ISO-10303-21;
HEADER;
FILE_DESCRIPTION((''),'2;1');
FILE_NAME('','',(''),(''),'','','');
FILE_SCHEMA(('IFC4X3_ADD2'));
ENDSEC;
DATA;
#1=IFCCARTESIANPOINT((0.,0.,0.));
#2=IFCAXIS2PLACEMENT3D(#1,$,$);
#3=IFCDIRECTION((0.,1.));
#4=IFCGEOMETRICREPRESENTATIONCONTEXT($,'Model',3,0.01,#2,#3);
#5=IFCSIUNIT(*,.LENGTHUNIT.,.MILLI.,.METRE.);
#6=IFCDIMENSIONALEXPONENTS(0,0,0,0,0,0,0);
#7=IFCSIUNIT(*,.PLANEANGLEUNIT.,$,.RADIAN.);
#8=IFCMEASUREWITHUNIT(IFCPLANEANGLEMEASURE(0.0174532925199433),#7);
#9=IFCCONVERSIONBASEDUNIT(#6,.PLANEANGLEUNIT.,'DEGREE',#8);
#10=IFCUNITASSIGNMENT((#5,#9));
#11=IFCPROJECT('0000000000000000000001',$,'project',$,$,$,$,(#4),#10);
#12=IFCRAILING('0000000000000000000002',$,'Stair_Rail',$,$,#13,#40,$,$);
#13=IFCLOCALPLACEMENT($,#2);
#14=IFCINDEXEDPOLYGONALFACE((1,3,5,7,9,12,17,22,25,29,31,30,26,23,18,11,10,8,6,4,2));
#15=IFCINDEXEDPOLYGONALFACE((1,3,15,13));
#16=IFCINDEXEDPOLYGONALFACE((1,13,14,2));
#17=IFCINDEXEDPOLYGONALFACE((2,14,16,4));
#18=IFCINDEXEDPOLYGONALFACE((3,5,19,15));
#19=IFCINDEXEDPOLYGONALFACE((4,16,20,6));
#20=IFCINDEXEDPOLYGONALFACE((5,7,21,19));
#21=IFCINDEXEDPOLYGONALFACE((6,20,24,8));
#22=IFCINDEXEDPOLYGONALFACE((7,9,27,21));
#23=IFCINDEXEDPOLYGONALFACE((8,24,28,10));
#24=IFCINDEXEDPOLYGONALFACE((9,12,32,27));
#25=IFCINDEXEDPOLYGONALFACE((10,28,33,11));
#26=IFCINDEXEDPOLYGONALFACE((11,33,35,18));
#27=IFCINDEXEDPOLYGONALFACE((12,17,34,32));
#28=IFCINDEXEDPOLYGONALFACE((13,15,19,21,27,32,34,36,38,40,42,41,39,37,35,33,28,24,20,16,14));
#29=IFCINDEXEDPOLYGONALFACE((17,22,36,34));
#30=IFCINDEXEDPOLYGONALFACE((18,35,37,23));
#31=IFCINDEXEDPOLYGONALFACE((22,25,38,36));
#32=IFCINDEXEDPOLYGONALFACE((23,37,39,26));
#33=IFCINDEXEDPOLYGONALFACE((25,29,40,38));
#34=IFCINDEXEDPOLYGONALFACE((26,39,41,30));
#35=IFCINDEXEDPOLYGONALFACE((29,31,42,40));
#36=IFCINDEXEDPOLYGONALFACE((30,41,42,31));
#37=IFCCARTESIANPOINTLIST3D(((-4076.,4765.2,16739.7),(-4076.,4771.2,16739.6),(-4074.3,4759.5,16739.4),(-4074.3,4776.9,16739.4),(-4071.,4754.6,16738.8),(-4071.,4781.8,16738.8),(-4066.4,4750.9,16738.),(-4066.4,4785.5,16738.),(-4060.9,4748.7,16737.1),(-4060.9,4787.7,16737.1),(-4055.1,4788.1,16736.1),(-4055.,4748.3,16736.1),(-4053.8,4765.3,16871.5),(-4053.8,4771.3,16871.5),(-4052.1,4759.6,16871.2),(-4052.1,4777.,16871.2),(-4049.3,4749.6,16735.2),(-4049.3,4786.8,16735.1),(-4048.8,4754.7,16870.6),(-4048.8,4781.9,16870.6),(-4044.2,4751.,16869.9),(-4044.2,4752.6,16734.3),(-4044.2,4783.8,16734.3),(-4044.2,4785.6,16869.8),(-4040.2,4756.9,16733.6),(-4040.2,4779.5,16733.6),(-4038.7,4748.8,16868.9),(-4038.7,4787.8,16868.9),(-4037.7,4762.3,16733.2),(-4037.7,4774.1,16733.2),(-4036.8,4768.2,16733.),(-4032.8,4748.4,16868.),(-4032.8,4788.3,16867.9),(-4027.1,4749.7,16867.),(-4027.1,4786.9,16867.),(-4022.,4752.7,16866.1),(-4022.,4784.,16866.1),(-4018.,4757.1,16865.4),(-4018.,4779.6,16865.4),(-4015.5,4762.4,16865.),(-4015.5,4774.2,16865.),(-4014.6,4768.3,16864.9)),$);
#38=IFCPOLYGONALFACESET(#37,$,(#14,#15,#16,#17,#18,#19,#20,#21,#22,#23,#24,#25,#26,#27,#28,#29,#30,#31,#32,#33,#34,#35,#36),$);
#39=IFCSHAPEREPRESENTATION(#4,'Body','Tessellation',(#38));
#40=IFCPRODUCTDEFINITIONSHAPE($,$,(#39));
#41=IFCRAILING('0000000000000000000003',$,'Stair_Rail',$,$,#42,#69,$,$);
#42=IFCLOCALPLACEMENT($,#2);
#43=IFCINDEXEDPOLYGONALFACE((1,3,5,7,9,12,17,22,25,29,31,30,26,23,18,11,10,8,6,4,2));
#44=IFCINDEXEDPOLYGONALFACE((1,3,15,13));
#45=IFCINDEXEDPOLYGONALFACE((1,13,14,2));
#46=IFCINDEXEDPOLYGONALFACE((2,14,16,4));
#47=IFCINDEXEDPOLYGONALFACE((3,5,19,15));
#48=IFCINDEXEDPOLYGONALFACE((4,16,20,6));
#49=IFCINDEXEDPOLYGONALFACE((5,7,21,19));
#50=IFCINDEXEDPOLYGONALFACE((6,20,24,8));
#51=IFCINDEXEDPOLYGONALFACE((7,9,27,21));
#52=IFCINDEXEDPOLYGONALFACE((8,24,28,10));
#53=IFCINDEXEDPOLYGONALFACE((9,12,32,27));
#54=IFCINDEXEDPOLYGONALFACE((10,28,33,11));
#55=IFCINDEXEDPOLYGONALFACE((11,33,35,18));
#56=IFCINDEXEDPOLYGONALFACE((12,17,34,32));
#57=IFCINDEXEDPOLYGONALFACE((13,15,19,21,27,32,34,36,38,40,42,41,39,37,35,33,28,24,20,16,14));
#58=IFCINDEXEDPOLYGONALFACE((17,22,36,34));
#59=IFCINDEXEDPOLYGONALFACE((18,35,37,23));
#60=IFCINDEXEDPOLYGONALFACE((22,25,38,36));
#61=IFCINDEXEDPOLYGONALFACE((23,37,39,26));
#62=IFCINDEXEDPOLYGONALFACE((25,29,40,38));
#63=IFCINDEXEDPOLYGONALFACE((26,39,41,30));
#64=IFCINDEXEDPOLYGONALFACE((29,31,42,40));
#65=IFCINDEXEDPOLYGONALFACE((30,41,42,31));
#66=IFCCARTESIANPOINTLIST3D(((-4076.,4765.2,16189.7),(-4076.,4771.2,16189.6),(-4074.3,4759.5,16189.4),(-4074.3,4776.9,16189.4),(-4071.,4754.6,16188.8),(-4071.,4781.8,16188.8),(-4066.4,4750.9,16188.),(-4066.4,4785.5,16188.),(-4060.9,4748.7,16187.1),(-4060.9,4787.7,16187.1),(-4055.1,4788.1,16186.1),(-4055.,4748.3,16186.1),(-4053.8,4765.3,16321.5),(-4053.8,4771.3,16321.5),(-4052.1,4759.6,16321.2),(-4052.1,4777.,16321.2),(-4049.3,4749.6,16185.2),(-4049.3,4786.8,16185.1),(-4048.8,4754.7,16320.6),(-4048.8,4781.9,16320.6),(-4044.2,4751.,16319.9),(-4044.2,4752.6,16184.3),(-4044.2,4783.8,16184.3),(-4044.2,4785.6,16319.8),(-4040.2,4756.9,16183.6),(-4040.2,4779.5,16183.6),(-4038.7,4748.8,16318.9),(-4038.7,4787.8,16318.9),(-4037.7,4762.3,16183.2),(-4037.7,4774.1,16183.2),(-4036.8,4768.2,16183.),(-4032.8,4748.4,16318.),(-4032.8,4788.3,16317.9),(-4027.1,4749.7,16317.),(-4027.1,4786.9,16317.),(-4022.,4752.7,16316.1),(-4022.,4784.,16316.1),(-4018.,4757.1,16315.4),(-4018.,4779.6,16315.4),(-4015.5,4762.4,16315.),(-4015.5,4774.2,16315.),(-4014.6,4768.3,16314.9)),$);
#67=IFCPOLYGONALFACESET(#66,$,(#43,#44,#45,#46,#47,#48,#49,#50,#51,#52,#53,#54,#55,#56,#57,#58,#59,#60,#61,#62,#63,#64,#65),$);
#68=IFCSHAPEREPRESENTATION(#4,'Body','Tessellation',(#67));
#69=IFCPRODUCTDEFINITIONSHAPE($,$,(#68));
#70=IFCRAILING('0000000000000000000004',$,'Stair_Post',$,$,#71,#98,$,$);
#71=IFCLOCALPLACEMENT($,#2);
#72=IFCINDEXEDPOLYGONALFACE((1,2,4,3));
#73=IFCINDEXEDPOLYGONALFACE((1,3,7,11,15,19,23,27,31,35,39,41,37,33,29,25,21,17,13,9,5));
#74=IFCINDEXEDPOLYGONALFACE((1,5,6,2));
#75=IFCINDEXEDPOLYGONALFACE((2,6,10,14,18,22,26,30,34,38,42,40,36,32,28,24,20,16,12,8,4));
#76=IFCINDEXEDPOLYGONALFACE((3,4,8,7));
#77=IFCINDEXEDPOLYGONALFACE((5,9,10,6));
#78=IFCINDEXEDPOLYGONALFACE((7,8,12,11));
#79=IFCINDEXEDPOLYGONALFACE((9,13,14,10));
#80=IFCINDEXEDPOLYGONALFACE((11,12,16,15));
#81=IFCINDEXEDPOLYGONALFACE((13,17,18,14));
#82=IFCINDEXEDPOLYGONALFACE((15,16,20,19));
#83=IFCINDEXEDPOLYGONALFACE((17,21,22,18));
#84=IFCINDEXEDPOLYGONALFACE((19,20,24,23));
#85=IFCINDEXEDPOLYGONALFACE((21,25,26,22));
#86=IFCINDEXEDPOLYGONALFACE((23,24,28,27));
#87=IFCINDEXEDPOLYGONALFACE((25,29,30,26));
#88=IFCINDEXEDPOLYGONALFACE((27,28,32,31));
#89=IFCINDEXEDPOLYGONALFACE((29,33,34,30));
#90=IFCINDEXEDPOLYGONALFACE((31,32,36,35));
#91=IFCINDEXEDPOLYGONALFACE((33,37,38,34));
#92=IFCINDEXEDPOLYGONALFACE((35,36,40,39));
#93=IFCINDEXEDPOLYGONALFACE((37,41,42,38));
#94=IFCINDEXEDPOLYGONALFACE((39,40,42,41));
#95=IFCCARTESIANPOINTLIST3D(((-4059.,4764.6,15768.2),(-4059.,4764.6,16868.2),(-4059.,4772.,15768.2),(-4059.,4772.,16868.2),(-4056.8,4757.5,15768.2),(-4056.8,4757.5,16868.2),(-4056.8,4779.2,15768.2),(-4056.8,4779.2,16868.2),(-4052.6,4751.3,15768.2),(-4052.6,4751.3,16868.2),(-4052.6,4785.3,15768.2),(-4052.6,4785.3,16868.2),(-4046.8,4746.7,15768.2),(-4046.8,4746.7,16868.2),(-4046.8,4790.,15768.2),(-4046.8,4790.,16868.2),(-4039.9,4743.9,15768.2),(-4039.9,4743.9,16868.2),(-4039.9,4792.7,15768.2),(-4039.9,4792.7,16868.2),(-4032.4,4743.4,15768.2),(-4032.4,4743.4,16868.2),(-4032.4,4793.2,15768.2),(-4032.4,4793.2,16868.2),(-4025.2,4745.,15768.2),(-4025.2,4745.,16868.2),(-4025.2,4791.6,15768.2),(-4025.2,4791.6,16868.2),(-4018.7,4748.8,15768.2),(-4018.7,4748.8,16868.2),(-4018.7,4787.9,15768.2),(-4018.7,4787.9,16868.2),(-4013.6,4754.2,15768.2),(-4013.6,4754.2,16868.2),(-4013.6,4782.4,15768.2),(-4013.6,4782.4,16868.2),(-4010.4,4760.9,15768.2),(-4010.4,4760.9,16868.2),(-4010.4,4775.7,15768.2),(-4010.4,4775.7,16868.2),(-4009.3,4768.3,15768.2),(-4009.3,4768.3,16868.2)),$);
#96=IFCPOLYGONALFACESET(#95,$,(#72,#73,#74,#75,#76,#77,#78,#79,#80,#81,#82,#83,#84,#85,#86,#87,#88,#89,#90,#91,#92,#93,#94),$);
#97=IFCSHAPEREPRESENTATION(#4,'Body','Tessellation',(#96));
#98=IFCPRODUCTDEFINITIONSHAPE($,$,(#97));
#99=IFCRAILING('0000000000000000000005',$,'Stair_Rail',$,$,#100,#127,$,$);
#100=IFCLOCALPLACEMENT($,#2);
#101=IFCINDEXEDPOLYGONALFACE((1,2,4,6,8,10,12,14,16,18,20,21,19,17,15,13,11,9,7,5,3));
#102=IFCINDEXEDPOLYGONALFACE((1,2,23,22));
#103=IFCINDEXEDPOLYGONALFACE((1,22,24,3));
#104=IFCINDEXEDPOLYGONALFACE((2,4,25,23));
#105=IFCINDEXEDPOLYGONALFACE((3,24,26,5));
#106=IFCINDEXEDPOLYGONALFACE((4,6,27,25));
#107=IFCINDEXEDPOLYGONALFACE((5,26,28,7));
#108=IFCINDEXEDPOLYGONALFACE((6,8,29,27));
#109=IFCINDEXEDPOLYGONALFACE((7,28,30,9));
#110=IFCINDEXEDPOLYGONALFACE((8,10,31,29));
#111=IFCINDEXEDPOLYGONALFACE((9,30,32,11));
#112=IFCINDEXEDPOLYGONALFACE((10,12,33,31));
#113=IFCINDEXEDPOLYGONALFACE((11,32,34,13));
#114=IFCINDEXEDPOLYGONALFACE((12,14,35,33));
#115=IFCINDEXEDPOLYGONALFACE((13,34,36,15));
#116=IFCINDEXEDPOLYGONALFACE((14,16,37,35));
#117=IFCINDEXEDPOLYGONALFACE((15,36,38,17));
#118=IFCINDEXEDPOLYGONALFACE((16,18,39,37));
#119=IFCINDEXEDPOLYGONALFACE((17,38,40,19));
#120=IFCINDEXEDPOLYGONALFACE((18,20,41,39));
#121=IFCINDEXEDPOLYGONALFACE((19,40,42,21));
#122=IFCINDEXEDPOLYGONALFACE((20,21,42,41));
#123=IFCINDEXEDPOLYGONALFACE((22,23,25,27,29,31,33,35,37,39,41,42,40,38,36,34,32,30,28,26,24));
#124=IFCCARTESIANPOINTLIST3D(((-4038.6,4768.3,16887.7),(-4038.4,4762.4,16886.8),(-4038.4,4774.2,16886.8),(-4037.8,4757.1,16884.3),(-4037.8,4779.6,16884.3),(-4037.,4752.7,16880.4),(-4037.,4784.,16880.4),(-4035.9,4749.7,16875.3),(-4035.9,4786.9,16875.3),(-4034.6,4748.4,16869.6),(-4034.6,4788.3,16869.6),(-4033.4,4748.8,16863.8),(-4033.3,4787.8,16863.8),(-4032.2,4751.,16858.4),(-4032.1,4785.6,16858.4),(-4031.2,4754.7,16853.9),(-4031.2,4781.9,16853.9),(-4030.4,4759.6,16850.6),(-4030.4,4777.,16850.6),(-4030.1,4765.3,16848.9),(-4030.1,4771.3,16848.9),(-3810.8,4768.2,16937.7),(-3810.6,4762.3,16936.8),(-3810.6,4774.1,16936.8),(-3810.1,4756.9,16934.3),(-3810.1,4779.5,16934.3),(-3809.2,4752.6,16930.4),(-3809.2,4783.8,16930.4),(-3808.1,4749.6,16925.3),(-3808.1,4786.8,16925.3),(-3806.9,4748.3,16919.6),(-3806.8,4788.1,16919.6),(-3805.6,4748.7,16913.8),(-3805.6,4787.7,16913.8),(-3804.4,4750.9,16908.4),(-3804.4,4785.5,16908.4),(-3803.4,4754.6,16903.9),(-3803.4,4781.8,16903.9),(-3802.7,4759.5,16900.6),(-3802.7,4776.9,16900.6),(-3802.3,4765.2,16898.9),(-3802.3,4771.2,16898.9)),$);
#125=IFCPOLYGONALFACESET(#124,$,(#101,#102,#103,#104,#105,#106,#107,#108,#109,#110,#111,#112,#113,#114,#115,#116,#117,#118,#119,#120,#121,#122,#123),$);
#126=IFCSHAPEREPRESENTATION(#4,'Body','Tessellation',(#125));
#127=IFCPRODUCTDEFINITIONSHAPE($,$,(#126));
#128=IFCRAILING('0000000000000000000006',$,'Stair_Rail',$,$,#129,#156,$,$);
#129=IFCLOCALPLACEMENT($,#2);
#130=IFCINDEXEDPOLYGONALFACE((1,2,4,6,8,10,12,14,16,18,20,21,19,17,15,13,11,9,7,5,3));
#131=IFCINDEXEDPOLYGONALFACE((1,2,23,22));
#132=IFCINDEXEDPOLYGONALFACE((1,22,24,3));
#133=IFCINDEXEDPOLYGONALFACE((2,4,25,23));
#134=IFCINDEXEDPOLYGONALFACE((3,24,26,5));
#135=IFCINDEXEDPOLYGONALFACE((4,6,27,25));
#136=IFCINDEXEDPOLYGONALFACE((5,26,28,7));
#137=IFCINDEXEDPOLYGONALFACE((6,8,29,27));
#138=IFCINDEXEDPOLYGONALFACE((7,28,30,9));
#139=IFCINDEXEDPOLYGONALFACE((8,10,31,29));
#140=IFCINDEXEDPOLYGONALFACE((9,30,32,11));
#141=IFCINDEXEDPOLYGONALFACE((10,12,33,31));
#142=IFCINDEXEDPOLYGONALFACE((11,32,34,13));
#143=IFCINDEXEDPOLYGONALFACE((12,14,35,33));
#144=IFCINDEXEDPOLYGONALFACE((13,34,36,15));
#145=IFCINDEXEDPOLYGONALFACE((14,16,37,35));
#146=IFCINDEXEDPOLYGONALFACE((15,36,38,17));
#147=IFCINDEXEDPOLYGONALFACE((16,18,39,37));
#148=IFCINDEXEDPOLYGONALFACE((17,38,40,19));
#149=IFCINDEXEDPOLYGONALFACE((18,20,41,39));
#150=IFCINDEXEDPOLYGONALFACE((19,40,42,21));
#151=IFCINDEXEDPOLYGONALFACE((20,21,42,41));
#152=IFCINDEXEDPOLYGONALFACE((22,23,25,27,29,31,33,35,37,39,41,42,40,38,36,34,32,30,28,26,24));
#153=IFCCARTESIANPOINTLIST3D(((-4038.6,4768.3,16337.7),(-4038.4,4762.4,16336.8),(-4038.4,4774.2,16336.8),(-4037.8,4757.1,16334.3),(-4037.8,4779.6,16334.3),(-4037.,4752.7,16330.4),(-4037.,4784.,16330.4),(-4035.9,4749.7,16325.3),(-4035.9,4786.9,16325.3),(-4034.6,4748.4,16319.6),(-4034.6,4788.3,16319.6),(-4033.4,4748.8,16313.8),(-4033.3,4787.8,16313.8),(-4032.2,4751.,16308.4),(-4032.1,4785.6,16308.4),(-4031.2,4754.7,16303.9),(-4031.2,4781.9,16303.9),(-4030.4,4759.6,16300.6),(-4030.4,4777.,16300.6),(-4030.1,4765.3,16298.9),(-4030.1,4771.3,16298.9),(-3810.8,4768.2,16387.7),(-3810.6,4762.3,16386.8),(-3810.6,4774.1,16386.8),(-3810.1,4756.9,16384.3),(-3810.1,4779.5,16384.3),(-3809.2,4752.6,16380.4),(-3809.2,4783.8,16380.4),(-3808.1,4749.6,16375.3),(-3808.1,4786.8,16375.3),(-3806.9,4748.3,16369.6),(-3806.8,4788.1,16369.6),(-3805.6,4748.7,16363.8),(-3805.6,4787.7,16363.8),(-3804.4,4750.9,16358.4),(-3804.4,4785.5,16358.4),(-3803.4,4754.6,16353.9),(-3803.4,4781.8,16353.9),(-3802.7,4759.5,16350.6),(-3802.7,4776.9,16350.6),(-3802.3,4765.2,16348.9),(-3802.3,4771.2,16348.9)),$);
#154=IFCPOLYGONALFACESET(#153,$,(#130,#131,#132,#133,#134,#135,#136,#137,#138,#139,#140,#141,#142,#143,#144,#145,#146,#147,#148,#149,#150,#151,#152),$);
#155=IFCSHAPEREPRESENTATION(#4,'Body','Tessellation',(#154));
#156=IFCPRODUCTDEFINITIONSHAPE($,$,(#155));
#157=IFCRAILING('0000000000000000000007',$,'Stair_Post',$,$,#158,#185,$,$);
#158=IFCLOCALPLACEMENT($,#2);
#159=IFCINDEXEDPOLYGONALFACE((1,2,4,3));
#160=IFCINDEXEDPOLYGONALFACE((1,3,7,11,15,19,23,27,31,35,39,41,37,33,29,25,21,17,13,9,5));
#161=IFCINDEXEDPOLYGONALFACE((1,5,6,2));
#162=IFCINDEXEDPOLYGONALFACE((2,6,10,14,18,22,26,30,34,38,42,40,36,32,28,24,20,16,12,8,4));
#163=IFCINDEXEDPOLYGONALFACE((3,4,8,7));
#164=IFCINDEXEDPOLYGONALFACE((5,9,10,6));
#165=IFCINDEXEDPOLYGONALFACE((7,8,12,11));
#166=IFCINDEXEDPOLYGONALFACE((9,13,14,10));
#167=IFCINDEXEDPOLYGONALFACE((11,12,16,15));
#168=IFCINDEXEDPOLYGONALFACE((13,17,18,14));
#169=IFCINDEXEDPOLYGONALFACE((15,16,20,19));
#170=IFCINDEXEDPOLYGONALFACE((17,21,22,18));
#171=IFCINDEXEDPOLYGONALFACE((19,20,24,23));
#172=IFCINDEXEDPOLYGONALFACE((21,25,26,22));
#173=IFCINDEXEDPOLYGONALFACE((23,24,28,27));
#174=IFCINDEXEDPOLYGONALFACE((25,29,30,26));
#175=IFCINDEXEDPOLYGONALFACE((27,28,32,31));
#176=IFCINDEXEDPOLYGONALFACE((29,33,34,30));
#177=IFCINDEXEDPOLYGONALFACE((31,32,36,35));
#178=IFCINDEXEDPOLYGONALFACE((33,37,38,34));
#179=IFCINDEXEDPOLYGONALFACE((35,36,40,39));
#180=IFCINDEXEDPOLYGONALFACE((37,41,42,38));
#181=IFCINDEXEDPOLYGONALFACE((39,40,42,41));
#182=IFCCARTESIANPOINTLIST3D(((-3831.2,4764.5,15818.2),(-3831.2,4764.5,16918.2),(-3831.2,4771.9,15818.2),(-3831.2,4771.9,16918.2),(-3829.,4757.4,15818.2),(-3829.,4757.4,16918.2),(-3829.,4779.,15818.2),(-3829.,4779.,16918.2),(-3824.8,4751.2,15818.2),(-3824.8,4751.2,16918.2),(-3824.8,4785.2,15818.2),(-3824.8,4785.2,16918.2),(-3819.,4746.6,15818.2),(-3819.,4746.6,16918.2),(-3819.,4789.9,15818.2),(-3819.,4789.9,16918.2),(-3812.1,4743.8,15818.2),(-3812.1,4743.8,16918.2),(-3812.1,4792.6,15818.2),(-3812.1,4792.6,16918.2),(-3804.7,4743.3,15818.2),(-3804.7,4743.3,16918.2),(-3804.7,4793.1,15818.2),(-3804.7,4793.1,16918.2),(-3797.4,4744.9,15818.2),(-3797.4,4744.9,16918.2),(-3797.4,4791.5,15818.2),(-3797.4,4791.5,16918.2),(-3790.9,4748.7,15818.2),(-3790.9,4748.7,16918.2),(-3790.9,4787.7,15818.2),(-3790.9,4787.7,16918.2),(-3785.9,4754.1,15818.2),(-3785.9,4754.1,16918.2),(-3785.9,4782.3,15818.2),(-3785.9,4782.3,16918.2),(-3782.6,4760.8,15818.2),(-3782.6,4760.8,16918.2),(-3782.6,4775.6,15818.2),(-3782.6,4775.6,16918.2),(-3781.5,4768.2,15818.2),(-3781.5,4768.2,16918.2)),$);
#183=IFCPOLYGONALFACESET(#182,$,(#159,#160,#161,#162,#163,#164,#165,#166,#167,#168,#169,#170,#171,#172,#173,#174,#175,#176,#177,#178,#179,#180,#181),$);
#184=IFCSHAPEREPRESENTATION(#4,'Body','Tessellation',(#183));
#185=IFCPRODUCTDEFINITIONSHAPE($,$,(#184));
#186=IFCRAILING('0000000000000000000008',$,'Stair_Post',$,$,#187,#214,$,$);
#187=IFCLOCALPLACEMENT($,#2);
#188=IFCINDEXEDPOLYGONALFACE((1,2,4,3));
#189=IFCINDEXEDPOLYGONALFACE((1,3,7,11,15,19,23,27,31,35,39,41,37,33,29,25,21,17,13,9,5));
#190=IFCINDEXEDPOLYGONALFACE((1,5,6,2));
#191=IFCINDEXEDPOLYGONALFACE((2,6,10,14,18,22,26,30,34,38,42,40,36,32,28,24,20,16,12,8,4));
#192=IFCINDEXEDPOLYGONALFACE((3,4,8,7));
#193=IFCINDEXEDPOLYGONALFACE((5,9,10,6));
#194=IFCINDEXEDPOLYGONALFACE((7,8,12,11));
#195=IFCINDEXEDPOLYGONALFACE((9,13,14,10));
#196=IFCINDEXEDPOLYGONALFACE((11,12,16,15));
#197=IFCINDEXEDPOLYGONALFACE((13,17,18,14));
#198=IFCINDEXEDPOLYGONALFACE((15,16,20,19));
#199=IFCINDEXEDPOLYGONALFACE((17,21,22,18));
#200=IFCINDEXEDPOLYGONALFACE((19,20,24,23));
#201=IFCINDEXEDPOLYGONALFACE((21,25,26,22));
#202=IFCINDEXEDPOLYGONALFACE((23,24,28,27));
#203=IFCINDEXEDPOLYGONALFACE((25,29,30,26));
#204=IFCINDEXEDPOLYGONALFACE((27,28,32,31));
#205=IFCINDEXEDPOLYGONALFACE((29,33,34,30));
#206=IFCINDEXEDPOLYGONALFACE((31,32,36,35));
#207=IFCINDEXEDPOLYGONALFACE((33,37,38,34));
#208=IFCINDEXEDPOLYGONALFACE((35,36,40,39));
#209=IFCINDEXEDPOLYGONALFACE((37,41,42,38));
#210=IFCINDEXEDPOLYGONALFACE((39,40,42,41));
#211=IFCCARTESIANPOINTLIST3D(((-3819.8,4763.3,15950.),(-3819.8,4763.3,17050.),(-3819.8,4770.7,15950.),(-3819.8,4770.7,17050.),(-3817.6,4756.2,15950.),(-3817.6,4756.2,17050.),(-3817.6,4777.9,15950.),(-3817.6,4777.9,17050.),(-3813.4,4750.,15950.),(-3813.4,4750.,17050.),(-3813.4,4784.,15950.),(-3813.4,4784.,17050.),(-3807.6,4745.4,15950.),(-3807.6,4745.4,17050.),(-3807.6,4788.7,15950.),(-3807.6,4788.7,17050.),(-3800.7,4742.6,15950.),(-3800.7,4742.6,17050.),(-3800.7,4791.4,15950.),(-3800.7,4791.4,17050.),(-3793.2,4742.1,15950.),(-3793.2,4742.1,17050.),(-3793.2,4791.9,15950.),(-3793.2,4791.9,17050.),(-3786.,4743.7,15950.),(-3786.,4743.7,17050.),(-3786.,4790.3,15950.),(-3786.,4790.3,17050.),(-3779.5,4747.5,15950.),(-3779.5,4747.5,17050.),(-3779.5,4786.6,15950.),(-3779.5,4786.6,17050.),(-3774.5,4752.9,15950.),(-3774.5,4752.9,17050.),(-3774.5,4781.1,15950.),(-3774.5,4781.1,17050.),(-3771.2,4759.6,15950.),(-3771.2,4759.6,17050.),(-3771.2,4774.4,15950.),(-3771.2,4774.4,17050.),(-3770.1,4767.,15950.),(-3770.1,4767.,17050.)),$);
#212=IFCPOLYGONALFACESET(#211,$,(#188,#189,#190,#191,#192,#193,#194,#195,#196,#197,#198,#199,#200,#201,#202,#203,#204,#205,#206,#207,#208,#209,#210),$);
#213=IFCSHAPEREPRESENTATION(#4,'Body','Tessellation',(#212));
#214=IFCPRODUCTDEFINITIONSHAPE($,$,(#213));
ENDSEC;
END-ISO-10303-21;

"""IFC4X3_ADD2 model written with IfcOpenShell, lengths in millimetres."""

from ifc_helpers import new_model, entity, si_unit, converted_unit, direction, frame, origin, context, project, circle, extrude, element, save


model = new_model("IFC4X3_ADD2")

# Units and contexts
model_context = context("Model", 3, precision=0.01, world=origin(), true_north=direction((0.0, 1.0)))
ifc_project = project(units=[si_unit("LENGTHUNIT", "METRE", prefix="MILLI"), converted_unit("PLANEANGLEUNIT", "DEGREE", entity("IfcPlaneAngleMeasure", 0.0174532925199433), si_unit("PLANEANGLEUNIT", "RADIAN"), dimensions=[0, 0, 0, 0, 0, 0, 0])], contexts=[model_context])

# Railings
element("IfcRailing", 1, Name="Stair_Rail", context=model_context, shape_type="SweptSolid", body=[
    entity("IfcSweptDiskSolid", entity("IfcPolyline", [entity("IfcCartesianPoint", [-4056.5, 4768.2, 16736.4]), entity("IfcCartesianPoint", [-4034.3, 4768.3, 16868.2])]), 20.0),
])
element("IfcRailing", 2, Name="Stair_Rail", context=model_context, shape_type="SweptSolid", body=[
    entity("IfcSweptDiskSolid", entity("IfcPolyline", [entity("IfcCartesianPoint", [-4056.5, 4768.2, 16186.4]), entity("IfcCartesianPoint", [-4034.3, 4768.3, 16318.2])]), 20.0),
])
element("IfcRailing", 3, Name="Stair_Post", context=model_context, shape_type="SweptSolid", body=[
    extrude(circle(Radius=25.0), frame((-4034.3, 4768.3, 15768.2)), (0.0, 0.0, 1.0), 1100.0),
])
element("IfcRailing", 4, Name="Stair_Rail", context=model_context, shape_type="SweptSolid", body=[
    entity("IfcSweptDiskSolid", entity("IfcPolyline", [entity("IfcCartesianPoint", [-4034.3, 4768.3, 16868.2]), entity("IfcCartesianPoint", [-3806.5, 4768.2, 16918.2])]), 20.0),
])
element("IfcRailing", 5, Name="Stair_Rail", context=model_context, shape_type="SweptSolid", body=[
    entity("IfcSweptDiskSolid", entity("IfcPolyline", [entity("IfcCartesianPoint", [-4034.3, 4768.3, 16318.2]), entity("IfcCartesianPoint", [-3806.5, 4768.2, 16368.2])]), 20.0),
])
element("IfcRailing", 6, Name="Stair_Post", context=model_context, shape_type="SweptSolid", body=[
    extrude(circle(Radius=25.0), frame((-3806.5, 4768.2, 15818.2)), (0.0, 0.0, 1.0), 1100.0),
])
element("IfcRailing", 7, Name="Stair_Post", context=model_context, shape_type="SweptSolid", body=[
    extrude(circle(Radius=25.0), frame((-3795.1, 4767.0, 15950.0)), (0.0, 0.0, 1.0), 1100.0),
])

save(model, "model.ifc")
